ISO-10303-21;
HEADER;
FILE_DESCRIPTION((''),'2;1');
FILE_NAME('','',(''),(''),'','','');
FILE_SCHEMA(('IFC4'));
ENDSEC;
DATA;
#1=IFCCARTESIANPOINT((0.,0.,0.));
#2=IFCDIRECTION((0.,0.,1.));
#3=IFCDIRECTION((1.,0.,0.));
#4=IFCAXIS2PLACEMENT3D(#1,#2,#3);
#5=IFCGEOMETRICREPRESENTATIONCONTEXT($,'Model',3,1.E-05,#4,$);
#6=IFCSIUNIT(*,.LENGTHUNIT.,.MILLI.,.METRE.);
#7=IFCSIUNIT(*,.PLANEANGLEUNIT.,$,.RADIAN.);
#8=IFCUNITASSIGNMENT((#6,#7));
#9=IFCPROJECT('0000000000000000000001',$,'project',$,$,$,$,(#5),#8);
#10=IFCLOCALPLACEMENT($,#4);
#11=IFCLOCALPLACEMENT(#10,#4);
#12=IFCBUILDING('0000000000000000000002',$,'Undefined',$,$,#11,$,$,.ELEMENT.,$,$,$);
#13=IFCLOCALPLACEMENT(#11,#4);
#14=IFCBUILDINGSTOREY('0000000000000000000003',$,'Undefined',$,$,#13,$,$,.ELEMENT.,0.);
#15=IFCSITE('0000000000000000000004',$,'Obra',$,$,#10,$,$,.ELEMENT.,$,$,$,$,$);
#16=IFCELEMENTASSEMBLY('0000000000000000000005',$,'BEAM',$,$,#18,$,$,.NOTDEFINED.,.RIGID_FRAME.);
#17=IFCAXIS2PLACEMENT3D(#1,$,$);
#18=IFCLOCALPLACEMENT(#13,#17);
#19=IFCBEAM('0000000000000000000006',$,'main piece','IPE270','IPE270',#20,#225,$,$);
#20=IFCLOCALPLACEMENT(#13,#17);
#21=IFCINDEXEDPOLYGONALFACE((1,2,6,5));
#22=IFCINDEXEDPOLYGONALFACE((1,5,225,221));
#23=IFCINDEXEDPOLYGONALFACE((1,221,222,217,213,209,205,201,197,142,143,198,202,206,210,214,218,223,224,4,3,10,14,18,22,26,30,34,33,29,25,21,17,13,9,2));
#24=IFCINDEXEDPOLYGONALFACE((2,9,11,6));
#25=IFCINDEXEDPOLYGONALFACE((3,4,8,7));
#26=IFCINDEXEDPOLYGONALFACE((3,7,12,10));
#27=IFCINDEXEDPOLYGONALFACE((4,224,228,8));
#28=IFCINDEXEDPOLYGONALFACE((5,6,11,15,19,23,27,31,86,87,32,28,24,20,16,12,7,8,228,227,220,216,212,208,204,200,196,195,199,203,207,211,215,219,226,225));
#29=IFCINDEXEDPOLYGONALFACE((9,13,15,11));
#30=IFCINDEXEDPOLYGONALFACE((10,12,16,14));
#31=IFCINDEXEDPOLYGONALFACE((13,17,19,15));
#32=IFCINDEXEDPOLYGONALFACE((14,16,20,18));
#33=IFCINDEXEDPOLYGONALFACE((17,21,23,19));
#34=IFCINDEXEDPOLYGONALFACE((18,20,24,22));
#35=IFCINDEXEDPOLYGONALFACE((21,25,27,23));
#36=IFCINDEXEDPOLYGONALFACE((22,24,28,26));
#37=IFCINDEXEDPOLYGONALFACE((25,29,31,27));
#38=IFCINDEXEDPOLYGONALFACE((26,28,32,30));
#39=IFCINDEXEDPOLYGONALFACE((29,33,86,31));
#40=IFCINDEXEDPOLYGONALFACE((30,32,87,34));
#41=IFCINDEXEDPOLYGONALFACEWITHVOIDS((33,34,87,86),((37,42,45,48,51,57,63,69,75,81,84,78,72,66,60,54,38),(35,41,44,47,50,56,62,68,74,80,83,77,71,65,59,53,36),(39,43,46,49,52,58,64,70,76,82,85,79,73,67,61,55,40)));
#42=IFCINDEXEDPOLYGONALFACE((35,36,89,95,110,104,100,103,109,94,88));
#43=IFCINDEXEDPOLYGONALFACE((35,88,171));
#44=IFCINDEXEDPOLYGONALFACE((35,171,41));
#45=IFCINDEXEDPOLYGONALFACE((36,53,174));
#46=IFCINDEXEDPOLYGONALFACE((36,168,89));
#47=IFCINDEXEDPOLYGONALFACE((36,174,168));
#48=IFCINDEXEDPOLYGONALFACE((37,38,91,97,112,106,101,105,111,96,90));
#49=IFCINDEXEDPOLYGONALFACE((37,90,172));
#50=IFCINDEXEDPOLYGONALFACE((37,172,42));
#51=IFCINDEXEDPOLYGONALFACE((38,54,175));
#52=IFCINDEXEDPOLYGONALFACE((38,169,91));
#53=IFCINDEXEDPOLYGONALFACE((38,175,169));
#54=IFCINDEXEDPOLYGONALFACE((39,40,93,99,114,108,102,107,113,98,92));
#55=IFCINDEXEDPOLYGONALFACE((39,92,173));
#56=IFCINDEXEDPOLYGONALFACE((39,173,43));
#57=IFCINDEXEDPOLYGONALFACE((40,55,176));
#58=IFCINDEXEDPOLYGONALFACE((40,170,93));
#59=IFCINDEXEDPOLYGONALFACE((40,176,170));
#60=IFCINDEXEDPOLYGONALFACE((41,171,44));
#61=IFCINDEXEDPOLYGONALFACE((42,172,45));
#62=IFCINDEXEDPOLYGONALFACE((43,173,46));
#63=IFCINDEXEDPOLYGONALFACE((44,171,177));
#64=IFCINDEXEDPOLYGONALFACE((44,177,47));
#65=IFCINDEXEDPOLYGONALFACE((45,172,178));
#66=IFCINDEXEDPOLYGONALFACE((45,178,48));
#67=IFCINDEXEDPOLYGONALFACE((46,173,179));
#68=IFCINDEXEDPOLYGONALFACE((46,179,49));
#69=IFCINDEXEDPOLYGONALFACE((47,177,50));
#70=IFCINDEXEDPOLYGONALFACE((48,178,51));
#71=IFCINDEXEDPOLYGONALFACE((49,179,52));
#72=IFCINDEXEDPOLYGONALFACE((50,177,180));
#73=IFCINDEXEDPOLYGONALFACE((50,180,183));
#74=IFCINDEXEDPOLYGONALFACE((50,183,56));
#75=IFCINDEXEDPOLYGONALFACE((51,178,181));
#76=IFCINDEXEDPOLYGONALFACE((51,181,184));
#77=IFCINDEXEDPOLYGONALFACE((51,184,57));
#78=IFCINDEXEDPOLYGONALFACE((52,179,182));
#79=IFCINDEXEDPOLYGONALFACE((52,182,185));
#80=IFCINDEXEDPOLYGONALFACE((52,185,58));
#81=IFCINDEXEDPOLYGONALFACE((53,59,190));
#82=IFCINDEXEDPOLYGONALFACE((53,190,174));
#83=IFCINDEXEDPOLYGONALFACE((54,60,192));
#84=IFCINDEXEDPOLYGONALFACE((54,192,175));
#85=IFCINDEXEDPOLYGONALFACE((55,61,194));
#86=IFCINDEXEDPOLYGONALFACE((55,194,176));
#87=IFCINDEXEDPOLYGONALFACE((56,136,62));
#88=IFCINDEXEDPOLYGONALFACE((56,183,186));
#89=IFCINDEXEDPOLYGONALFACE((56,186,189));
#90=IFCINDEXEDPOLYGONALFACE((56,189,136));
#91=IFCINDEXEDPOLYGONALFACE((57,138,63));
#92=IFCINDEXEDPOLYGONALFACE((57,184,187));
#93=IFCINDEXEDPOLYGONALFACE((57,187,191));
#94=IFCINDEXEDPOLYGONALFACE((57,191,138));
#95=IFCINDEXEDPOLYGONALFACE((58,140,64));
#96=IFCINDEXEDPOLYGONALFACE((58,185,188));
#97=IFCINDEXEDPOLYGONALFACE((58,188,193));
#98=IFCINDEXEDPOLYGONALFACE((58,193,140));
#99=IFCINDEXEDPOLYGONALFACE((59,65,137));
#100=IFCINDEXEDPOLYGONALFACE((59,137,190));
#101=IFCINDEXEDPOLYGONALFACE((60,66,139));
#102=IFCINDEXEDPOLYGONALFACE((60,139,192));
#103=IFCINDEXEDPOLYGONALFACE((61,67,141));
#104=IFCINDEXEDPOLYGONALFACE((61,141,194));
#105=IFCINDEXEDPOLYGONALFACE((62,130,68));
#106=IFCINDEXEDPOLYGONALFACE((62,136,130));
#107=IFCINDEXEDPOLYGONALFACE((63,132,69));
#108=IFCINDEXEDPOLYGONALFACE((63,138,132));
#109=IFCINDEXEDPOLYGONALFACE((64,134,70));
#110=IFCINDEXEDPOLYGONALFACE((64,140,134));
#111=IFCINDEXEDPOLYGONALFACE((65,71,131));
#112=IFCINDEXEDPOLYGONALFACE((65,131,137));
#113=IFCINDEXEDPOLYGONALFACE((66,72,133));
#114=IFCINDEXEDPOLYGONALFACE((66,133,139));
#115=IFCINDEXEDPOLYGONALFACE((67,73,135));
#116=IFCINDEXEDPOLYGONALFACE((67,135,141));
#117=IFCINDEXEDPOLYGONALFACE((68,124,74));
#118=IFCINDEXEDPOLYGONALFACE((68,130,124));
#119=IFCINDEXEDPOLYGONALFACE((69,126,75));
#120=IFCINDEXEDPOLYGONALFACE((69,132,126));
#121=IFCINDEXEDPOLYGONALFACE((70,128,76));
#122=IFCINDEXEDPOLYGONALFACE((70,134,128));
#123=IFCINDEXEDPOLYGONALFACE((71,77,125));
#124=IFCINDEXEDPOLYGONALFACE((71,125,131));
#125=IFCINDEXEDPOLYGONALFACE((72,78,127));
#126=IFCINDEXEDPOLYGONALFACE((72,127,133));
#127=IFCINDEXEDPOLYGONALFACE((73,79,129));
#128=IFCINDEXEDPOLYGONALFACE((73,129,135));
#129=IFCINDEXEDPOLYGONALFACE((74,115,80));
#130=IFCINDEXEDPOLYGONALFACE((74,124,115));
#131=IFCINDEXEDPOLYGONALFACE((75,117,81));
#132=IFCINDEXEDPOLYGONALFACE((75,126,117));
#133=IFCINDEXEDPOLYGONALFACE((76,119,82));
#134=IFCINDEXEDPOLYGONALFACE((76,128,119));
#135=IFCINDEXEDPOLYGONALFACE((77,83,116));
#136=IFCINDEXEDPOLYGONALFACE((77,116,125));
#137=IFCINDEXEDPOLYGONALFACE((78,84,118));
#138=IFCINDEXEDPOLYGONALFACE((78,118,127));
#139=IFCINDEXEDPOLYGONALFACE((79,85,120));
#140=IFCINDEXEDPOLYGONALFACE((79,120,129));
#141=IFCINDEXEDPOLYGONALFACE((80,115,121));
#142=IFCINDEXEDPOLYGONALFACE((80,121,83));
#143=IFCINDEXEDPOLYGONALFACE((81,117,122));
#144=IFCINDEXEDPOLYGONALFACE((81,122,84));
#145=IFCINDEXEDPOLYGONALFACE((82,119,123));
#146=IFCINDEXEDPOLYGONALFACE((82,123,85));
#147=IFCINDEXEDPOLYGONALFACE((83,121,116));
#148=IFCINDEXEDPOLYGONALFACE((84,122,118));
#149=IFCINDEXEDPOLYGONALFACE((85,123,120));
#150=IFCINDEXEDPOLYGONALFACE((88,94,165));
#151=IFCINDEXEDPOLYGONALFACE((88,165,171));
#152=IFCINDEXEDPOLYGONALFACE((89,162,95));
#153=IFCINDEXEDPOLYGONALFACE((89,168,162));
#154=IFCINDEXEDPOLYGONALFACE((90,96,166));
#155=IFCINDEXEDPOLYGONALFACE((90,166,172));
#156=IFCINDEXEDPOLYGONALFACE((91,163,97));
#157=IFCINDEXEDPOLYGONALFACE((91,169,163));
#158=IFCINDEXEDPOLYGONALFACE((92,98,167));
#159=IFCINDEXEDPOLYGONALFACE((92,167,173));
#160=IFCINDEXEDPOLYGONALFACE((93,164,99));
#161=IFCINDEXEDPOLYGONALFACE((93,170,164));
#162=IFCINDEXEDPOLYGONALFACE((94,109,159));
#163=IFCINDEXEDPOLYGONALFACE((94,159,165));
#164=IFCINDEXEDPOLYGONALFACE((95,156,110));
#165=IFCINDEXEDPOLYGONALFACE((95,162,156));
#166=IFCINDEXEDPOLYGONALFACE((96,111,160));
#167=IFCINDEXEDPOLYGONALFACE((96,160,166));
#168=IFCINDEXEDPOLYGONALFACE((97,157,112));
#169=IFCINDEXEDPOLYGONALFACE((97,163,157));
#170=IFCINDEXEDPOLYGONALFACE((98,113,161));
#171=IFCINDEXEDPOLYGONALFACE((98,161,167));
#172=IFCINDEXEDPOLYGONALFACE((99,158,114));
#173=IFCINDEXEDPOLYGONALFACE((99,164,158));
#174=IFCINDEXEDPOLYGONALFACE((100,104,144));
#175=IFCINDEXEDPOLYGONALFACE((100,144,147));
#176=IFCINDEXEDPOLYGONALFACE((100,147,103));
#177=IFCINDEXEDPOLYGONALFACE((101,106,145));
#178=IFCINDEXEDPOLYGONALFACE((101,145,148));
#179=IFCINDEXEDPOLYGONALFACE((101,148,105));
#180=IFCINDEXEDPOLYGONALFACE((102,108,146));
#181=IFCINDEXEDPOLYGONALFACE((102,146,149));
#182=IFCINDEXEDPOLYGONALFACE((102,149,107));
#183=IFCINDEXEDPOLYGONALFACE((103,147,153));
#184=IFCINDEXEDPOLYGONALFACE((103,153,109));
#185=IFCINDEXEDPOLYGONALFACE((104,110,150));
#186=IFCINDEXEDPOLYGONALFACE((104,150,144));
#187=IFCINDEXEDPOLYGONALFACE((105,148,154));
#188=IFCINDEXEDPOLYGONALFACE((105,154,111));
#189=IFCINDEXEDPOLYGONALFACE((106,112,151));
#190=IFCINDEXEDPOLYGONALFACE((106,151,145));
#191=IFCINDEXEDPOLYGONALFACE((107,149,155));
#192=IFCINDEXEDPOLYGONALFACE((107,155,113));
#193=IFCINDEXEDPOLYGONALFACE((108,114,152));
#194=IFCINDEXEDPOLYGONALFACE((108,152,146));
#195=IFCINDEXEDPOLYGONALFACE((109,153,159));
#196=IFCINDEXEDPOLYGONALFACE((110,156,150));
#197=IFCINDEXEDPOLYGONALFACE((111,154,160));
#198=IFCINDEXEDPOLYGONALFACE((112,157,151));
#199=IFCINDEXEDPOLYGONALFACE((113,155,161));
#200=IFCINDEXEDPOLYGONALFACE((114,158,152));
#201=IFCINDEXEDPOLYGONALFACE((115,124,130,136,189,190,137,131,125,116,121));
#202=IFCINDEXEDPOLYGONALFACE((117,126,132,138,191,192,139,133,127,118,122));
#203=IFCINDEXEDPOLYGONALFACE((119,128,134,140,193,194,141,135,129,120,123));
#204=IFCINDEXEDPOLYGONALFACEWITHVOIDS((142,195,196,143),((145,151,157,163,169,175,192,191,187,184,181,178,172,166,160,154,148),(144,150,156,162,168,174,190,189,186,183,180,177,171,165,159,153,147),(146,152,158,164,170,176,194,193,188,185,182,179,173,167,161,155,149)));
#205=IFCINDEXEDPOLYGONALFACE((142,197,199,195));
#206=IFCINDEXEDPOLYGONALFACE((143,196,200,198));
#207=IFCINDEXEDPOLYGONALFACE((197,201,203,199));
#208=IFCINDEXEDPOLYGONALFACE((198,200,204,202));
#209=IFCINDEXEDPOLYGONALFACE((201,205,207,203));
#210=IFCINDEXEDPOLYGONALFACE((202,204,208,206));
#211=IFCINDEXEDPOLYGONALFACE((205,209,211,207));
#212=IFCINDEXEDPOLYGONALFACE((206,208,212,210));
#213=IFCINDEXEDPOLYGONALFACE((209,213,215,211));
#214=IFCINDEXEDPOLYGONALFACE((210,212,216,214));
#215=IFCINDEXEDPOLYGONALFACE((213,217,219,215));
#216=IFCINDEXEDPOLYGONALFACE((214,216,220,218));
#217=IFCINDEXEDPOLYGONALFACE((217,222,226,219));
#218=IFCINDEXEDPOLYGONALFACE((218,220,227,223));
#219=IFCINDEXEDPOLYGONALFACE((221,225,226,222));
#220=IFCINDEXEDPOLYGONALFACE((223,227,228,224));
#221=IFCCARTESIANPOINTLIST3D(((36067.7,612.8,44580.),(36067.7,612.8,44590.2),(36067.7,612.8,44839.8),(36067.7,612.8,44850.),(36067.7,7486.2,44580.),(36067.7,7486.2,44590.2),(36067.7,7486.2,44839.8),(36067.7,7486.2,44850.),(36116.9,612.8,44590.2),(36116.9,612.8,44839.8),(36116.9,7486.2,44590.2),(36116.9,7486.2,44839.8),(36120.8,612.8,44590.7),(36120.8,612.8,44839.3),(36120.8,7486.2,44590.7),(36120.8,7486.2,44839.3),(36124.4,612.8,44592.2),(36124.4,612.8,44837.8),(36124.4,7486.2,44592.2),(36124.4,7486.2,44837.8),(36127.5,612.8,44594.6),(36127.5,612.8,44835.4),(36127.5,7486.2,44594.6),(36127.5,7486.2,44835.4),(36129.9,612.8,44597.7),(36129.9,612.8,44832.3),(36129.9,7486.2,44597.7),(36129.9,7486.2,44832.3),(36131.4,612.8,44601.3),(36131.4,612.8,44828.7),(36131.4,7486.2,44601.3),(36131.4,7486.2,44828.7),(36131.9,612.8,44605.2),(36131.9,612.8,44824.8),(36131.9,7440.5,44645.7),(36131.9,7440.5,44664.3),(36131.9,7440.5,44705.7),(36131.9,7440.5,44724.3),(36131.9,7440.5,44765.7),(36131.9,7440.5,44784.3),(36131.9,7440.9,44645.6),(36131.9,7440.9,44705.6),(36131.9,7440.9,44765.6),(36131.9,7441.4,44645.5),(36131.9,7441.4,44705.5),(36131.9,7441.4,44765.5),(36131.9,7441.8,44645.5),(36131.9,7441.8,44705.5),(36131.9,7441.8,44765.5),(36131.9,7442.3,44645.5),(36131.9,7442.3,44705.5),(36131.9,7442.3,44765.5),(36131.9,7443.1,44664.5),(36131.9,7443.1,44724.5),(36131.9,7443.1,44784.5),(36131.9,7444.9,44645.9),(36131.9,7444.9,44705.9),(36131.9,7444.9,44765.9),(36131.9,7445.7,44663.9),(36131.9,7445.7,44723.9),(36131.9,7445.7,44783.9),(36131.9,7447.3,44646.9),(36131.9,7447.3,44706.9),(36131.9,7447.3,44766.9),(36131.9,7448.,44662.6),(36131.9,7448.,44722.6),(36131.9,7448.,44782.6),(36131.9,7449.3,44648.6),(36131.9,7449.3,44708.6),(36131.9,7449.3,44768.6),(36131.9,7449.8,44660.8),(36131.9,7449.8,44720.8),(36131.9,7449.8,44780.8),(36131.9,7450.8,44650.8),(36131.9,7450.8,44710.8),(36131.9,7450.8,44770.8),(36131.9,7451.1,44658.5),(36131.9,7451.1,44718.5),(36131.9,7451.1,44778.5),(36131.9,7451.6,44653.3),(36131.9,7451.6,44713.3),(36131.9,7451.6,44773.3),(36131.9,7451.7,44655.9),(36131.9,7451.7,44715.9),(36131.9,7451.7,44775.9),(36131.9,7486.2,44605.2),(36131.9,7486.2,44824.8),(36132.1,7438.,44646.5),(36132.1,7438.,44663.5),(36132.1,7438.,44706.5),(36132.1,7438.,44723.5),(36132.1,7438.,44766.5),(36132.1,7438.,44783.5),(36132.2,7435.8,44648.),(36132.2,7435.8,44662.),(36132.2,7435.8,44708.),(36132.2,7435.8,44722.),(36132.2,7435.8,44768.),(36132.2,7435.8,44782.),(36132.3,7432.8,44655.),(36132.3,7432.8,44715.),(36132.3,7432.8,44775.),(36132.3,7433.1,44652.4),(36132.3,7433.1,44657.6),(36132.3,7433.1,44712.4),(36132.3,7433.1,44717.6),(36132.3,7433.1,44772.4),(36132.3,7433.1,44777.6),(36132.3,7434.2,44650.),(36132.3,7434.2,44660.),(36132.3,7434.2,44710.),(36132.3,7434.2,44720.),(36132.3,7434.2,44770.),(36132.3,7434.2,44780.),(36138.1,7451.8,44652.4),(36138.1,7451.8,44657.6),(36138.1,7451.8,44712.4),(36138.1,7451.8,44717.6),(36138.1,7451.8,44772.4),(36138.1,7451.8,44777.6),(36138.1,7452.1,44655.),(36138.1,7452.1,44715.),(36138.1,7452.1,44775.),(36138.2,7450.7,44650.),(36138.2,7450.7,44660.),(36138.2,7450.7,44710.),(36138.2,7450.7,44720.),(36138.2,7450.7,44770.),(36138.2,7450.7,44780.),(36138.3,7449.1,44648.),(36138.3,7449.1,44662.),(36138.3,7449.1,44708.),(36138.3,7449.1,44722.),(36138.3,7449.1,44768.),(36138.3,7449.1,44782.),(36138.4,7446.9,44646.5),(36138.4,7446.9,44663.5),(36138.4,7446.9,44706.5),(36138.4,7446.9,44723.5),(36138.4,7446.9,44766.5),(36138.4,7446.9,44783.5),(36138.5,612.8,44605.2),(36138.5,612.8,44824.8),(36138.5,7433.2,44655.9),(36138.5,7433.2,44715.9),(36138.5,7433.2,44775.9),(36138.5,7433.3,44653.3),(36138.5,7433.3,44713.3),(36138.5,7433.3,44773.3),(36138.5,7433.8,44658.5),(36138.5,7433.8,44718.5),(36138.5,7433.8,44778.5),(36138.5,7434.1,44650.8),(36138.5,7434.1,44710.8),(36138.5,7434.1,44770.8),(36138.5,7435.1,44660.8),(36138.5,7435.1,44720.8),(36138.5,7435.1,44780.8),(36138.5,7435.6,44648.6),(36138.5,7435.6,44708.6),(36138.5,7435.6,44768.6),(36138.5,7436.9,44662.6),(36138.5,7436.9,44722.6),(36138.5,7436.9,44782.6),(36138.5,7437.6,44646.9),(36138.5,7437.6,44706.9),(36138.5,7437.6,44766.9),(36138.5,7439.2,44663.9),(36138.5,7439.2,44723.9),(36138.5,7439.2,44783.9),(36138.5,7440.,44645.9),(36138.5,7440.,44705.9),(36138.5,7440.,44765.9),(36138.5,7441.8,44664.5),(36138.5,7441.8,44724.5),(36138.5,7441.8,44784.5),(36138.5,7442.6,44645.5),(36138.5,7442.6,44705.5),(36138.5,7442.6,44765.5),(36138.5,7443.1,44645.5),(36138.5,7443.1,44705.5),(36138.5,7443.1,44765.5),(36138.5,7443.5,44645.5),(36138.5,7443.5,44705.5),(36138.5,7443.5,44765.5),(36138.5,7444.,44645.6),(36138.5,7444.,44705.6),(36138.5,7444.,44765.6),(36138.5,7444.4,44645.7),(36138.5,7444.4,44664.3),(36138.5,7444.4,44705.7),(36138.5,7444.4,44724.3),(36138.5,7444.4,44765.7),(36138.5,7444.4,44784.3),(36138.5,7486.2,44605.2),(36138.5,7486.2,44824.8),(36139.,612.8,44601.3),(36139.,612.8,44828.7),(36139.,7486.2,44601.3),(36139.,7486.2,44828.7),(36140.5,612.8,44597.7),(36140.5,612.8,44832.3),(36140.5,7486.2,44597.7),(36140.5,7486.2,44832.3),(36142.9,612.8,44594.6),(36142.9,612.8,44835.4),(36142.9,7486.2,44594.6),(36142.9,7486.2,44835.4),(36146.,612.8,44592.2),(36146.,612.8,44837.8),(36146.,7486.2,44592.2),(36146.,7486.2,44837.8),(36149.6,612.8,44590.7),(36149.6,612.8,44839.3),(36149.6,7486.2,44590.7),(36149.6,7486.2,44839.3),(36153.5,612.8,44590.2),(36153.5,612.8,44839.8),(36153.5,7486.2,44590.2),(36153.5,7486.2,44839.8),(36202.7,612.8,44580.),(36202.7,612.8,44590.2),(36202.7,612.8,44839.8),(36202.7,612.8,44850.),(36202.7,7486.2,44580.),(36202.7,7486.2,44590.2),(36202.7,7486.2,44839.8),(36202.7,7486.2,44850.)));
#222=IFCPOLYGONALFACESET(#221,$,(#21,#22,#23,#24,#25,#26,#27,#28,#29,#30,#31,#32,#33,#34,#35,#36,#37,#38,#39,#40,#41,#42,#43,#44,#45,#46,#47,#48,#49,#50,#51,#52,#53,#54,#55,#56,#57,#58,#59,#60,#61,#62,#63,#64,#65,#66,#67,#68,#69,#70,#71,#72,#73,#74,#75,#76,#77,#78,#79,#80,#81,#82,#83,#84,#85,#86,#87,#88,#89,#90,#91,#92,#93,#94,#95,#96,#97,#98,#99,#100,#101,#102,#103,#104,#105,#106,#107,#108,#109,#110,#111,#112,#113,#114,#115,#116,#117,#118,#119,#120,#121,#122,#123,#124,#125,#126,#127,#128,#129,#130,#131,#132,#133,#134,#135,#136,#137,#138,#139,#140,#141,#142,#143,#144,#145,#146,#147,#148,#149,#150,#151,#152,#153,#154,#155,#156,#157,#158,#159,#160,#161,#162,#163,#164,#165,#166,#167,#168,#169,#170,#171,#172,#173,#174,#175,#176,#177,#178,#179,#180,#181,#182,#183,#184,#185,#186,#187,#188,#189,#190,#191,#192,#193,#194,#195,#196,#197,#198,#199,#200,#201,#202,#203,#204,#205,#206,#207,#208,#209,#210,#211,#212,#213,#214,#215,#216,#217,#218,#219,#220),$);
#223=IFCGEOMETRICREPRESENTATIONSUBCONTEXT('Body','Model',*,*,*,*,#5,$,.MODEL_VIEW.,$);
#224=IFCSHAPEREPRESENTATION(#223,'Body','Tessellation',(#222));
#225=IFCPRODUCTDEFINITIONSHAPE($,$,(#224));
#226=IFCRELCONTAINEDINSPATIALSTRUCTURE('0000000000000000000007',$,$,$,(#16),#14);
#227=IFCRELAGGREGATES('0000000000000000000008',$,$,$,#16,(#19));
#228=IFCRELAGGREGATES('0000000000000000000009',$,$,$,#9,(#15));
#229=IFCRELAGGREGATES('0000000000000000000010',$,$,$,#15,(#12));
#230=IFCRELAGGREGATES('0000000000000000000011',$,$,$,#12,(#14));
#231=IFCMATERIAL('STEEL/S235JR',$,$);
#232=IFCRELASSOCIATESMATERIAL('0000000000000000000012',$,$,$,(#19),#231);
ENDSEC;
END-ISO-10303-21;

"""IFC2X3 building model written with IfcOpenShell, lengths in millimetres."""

from ifc_helpers import new_model, si_unit, frame, origin_with_axes, origin_2d_with_axis, place, context, subcontext, project, spatial, circle, i_section, extrude, clip, halfspace, source, transform, mapped, material, element, aggregate, save


model = new_model("IFC2X3")

# Units and contexts
model_context = context("Model", 3, precision=1e-05, world=origin_with_axes())
body_context = subcontext(model_context, "Body", "Model", "MODEL_VIEW")
ifc_project = project(units=[si_unit("LENGTHUNIT", "METRE", prefix="MILLI"), si_unit("PLANEANGLEUNIT", "RADIAN")], contexts=[model_context])

# Site, building, storey
site_placement = place(None, origin_with_axes())
site = spatial("IfcSite", under=ifc_project, at=site_placement, Name="Obra", CompositionType="ELEMENT")
building_placement = place(site_placement, origin_with_axes())
building = spatial("IfcBuilding", under=site, at=building_placement, Name="Undefined", CompositionType="ELEMENT")
storey_placement = place(building_placement, origin_with_axes())
storey = spatial("IfcBuildingStorey", under=building, at=storey_placement, Name="Undefined", CompositionType="ELEMENT", Elevation=0.0)

# Shared definitions
ifc_material_1 = material(Name="STEEL/S235JR")

# Element assembly, beam, opening
shared_shape_1 = source(origin_with_axes(), body_context, "Body", "SweptSolid", [
    extrude(circle(Radius=9.5, at=origin_2d_with_axis()), frame((0.0, -34.3, 0.0), z_axis=(0.0, 1.0, 0.0), x_axis=(1.0, 0.0, 0.0)), (0.0, 0.0, 1.0), 6.8),
])
assembly_1_placement = place(storey_placement, origin_with_axes())
assembly_1 = element("IfcElementAssembly", 1, at=assembly_1_placement, inside=storey, Name="BEAM", AssemblyPlace="NOTDEFINED", PredefinedType="RIGID_FRAME")
beam_1_placement = place(assembly_1_placement, frame((36135.2, 612.8, 44715.0), z_axis=(0.0, 0.0, 1.0), x_axis=(0.0, 1.0, 0.0)))
beam_1 = element("IfcBeam", 2, at=beam_1_placement, material=ifc_material_1, Name="main piece", Description="IPE270", ObjectType="IPE270", context=body_context, shape_type="Clipping", body=[
    clip(extrude(i_section(OverallWidth=135.0, OverallDepth=270.0, WebThickness=6.6, FlangeThickness=10.2, FilletRadius=15.0, at=origin_2d_with_axis()), frame((6873.4, 0.0, 0.0), z_axis=(-1.0, 0.0, 0.0), x_axis=(0.0, -1.0, 0.0)), (0.0, 0.0, 1.0), 6873.4), halfspace(frame((6884.2, -88.1, -120.0), z_axis=(0.998477, 0.055171, 0.0), x_axis=(0.0, 0.0, 1.0)), False)),
])
opening_1_placement = place(assembly_1_placement, frame((36163.3, 7494.1, 44835.0), z_axis=(0.055152, -0.998478, 0.0), x_axis=(0.0, 0.0, -1.0)))
element("IfcOpeningElement", 3, at=opening_1_placement, cuts=beam_1, ObjectType="Opening", context=body_context, shape_type="MappedRepresentation", body=[
    mapped(shared_shape_1, transform((60.0, 0.0, 50.0))),
    mapped(shared_shape_1, transform((120.0, 0.0, 50.0))),
    mapped(shared_shape_1, transform((180.0, 0.0, 50.0))),
])

aggregate(assembly_1, [beam_1])

save(model, "model.ifc")
